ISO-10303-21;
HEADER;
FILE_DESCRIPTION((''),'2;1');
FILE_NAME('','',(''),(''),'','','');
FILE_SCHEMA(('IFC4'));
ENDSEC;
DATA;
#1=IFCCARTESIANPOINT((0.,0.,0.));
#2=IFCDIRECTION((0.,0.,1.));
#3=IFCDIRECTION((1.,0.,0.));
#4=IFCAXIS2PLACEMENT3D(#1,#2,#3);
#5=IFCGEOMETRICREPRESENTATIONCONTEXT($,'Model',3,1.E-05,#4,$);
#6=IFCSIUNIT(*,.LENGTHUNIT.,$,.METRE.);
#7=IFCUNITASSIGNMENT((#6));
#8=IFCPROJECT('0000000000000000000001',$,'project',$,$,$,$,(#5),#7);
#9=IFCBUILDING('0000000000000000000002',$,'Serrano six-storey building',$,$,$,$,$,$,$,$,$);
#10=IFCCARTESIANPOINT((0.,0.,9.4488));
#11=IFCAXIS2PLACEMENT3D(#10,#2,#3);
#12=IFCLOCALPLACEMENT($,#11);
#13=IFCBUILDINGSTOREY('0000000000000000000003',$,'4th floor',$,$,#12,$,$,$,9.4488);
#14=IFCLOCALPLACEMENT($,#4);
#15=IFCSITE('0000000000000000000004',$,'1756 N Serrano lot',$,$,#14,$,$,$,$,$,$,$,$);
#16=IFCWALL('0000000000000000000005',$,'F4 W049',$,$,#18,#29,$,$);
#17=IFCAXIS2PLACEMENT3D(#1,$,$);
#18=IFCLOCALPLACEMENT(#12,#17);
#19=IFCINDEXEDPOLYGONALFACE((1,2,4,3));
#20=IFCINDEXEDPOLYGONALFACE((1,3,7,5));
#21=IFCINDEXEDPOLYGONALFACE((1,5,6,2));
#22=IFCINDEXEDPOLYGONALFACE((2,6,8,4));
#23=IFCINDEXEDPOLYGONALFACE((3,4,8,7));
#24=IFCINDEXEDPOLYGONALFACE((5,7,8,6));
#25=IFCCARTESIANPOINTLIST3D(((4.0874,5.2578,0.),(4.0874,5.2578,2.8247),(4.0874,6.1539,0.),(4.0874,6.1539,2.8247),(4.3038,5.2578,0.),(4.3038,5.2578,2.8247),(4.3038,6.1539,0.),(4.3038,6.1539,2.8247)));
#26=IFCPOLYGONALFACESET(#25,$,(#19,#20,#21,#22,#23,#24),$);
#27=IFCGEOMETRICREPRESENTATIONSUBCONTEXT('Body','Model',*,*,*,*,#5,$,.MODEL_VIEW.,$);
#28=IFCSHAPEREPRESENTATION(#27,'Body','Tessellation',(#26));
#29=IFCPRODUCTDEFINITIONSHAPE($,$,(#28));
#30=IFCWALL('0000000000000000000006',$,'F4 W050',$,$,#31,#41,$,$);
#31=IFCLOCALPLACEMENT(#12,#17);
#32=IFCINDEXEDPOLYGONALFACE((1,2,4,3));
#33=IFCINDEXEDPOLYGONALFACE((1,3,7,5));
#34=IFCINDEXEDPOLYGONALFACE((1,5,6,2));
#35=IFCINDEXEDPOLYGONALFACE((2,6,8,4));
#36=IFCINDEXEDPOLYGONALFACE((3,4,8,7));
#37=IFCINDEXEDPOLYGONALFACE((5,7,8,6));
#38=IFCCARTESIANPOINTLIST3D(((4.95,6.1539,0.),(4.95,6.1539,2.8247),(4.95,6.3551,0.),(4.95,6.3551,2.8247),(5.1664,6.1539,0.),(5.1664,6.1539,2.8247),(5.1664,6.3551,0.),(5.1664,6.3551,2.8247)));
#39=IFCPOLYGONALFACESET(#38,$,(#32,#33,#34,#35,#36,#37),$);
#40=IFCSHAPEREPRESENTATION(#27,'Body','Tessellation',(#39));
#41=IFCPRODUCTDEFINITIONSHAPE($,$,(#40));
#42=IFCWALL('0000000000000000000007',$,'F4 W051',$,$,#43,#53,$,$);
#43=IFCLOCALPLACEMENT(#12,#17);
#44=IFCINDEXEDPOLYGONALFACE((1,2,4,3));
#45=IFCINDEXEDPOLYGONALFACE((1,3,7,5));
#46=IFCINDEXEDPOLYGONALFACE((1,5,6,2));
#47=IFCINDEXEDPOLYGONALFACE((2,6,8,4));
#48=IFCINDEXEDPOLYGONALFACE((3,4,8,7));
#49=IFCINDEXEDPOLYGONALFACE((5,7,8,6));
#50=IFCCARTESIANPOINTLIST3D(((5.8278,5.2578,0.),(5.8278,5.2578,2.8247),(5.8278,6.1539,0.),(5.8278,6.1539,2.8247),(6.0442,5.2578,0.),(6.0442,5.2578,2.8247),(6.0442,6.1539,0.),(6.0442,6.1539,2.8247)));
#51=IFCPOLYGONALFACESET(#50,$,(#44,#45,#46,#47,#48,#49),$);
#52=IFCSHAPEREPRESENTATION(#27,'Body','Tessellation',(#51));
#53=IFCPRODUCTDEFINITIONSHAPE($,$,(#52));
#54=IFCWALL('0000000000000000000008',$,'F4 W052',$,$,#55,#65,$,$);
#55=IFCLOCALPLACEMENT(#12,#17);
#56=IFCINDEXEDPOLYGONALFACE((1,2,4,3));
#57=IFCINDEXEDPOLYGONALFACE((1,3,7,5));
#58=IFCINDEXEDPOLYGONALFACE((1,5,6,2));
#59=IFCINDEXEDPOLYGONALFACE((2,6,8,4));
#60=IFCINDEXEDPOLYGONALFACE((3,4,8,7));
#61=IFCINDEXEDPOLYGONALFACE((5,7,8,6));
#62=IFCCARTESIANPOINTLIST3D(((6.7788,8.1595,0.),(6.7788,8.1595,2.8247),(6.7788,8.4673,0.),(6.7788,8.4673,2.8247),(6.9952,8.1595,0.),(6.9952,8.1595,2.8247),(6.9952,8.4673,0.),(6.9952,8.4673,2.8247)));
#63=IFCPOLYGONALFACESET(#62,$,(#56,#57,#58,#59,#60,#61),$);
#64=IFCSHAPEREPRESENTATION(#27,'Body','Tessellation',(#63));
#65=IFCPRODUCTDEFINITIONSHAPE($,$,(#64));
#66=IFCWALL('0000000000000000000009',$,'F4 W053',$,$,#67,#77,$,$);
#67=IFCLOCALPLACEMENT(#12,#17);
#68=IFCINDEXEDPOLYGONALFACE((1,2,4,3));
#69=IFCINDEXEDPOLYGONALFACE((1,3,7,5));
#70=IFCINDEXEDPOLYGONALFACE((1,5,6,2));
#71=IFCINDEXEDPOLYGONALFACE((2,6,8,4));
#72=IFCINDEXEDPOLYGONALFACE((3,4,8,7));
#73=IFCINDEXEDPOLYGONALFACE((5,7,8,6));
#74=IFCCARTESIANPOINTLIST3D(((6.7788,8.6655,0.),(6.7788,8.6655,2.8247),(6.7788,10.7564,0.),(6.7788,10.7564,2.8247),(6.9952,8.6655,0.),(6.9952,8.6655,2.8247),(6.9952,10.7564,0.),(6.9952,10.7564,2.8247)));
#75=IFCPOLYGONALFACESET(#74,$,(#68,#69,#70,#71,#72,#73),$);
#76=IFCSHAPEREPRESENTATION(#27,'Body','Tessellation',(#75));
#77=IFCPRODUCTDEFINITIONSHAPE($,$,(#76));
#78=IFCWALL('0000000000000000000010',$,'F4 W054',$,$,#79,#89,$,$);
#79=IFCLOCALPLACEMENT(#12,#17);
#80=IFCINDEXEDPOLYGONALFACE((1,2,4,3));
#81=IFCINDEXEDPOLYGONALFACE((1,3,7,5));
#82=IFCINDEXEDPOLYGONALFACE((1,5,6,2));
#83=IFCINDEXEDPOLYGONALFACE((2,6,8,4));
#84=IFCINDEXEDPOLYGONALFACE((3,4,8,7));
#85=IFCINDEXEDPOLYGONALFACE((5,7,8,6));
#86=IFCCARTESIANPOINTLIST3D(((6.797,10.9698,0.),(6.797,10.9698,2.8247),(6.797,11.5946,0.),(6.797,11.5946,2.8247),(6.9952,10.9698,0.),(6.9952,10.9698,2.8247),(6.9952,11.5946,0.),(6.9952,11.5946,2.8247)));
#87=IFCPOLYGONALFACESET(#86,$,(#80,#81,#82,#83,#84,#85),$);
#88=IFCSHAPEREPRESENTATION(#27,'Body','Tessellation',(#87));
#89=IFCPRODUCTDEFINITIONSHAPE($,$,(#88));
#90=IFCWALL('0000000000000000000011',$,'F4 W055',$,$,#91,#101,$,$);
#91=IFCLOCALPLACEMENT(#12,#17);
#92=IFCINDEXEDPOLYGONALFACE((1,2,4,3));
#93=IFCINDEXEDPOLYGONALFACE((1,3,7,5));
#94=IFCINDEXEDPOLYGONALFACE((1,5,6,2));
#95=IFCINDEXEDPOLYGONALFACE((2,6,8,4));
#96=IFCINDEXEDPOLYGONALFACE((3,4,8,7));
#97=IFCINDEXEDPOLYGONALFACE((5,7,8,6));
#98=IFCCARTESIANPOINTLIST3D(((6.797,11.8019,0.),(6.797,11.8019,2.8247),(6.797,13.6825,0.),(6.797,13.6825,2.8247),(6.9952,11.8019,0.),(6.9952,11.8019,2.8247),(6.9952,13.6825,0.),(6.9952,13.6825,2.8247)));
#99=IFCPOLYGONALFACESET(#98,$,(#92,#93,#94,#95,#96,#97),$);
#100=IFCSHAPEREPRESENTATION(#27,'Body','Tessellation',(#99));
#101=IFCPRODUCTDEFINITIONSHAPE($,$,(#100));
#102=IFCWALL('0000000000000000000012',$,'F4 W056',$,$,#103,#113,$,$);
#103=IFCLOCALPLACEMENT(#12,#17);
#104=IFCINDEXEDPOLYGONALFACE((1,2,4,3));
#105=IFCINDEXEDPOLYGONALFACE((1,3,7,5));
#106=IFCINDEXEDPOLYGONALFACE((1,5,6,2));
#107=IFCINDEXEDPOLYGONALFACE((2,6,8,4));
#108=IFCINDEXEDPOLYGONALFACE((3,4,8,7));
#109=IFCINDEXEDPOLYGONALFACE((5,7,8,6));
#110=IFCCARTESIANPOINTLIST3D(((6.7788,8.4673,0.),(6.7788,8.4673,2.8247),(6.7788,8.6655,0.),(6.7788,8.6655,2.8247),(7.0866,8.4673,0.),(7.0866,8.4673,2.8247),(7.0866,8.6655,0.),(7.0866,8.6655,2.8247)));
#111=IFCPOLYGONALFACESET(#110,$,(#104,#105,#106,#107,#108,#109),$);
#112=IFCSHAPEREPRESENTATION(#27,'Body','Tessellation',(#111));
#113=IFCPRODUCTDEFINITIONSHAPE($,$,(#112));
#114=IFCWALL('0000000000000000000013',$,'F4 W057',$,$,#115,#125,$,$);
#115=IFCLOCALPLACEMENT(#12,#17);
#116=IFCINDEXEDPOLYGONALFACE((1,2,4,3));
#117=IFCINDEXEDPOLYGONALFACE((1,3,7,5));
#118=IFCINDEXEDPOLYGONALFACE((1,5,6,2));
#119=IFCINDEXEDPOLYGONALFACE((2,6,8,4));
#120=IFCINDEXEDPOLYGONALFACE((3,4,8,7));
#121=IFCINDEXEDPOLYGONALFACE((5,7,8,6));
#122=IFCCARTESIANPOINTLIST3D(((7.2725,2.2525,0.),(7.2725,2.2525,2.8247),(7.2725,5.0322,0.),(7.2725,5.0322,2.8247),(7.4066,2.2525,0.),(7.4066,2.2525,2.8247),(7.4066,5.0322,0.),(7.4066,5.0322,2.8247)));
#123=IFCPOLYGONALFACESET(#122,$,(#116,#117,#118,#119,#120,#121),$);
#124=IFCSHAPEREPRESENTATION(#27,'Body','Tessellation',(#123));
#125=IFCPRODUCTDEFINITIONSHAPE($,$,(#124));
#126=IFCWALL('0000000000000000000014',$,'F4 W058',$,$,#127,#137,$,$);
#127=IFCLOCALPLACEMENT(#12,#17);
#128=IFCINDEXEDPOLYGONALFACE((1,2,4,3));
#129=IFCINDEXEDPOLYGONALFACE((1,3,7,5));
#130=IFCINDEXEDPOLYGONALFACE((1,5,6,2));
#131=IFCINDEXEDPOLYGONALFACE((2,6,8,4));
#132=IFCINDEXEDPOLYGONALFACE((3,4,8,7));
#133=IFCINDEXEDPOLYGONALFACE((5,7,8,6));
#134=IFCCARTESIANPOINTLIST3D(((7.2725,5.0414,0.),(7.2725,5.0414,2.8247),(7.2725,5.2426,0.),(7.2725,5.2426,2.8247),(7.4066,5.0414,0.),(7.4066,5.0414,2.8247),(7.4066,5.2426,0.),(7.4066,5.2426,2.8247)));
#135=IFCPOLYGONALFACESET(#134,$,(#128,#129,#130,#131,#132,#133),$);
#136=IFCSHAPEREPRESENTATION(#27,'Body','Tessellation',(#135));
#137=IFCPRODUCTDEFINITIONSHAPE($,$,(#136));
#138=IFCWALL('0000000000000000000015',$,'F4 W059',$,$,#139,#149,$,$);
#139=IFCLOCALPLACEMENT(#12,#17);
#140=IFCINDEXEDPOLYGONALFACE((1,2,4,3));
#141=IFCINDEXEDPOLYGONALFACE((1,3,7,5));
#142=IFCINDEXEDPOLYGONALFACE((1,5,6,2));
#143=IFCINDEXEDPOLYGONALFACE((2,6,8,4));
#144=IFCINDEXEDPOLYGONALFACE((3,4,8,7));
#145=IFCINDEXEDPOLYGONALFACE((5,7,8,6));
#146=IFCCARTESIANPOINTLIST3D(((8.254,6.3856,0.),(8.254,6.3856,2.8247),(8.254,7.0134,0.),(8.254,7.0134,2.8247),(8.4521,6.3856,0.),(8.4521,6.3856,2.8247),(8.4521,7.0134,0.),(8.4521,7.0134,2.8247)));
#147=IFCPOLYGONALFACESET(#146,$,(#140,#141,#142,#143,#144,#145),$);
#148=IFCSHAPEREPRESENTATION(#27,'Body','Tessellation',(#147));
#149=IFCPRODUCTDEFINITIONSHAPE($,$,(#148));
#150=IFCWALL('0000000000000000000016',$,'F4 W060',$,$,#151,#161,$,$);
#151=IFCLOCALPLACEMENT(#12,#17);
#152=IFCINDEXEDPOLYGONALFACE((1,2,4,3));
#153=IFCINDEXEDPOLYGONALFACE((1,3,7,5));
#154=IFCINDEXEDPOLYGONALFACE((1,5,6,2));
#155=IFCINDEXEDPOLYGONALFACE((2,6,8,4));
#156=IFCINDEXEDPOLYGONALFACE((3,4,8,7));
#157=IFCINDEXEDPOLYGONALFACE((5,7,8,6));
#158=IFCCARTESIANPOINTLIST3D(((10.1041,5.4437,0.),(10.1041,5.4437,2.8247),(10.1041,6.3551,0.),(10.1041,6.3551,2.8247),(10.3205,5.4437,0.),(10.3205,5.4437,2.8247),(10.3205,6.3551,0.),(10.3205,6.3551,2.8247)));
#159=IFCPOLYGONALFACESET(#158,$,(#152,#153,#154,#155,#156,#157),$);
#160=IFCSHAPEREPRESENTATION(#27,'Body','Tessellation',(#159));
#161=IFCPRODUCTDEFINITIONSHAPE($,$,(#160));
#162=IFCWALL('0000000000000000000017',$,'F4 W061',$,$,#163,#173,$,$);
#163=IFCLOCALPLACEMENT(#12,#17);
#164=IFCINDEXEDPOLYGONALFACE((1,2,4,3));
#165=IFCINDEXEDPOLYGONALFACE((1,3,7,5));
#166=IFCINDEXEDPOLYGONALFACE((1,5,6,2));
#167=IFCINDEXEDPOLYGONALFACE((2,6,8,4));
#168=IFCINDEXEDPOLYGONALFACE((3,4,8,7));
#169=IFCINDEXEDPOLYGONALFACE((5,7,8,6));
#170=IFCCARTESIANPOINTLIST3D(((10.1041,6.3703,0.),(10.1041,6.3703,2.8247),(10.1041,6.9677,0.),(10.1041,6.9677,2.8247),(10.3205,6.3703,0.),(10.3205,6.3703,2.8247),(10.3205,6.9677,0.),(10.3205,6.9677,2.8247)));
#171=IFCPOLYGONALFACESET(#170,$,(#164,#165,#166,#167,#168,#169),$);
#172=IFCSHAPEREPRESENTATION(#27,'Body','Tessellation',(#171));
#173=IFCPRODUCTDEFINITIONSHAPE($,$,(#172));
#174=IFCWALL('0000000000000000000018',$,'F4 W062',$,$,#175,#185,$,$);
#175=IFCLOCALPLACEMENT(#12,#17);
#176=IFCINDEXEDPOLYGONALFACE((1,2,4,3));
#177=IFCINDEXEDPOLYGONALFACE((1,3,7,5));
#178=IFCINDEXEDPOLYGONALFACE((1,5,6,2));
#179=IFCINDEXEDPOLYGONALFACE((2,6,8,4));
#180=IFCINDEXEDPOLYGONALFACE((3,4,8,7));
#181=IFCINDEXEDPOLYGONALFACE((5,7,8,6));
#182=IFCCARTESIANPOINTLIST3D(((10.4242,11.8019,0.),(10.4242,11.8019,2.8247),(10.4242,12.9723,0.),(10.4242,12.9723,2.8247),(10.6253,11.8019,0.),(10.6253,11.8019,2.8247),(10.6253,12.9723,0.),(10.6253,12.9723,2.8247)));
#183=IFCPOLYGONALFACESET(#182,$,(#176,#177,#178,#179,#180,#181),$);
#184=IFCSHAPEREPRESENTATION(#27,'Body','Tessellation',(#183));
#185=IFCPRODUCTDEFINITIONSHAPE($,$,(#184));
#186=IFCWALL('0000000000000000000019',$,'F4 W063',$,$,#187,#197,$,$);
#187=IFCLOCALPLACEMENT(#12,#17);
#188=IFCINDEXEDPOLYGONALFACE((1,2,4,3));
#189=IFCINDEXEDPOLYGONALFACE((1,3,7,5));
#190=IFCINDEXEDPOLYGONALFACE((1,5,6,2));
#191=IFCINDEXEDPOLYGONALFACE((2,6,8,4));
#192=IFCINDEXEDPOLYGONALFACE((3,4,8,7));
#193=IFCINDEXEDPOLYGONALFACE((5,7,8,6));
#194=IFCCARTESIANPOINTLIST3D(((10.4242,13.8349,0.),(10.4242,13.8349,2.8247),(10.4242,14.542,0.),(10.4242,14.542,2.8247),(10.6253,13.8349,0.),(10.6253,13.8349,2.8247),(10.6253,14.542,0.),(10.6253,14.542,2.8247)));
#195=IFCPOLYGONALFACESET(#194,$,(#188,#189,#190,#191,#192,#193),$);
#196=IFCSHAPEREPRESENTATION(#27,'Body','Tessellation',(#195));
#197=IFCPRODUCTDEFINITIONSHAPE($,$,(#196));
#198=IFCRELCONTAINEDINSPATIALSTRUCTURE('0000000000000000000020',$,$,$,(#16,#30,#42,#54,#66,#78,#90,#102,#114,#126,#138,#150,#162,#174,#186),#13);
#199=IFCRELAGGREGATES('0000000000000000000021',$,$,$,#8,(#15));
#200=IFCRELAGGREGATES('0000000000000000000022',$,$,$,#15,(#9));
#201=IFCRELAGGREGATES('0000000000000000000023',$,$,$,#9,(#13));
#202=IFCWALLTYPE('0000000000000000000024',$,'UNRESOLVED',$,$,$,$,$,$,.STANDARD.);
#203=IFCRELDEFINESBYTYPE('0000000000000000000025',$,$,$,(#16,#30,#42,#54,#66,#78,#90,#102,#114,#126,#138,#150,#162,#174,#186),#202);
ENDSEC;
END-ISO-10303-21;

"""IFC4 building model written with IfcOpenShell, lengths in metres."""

from ifc_helpers import new_model, si_unit, frame, origin_with_axes, place, context, subcontext, project, spatial, polyline, outline, extrude, type_object, element, save


model = new_model("IFC4")

# Units and contexts
model_context = context("Model", 3, precision=1e-05, world=origin_with_axes())
body_context = subcontext(model_context, "Body", "Model", "MODEL_VIEW")
ifc_project = project(units=[si_unit("LENGTHUNIT", "METRE")], contexts=[model_context])

# Site, building, storey
site_placement = place(None, origin_with_axes())
site = spatial("IfcSite", under=ifc_project, at=site_placement, Name="1756 N Serrano lot")
building = spatial("IfcBuilding", under=site, Name="Serrano six-storey building")
storey_placement = place(None, frame((0.0, 0.0, 9.4488), z_axis=(0.0, 0.0, 1.0), x_axis=(1.0, 0.0, 0.0)))
storey = spatial("IfcBuildingStorey", under=building, at=storey_placement, Name="4th floor", Elevation=9.4488)

# Walls
wall_type = type_object("IfcWallType", Name="UNRESOLVED", PredefinedType="STANDARD")
wall_1_placement = place(storey_placement, frame((0.0, 0.0, -9.4488), z_axis=(0.0, 0.0, 1.0), x_axis=(1.0, 0.0, 0.0)))
element("IfcWall", 1, at=wall_1_placement, inside=storey, type_object=wall_type, Name="F4 W049", context=body_context, shape_type="SweptSolid", body=[
    extrude(outline(polyline([(4.0874, 6.1539), (4.3038, 6.1539), (4.3038, 5.2578), (4.0874, 5.2578), (4.0874, 6.1539)])), frame((0.0, 0.0, 9.4488)), (0.0, 0.0, 1.0), 2.8247),
])
wall_2_placement = place(storey_placement, frame((0.0, 0.0, -9.4488), z_axis=(0.0, 0.0, 1.0), x_axis=(1.0, 0.0, 0.0)))
element("IfcWall", 2, at=wall_2_placement, inside=storey, type_object=wall_type, Name="F4 W050", context=body_context, shape_type="SweptSolid", body=[
    extrude(outline(polyline([(4.95, 6.3551), (5.1664, 6.3551), (5.1664, 6.1539), (4.95, 6.1539), (4.95, 6.3551)])), frame((0.0, 0.0, 9.4488)), (0.0, 0.0, 1.0), 2.8247),
])
wall_3_placement = place(storey_placement, frame((0.0, 0.0, -9.4488), z_axis=(0.0, 0.0, 1.0), x_axis=(1.0, 0.0, 0.0)))
element("IfcWall", 3, at=wall_3_placement, inside=storey, type_object=wall_type, Name="F4 W051", context=body_context, shape_type="SweptSolid", body=[
    extrude(outline(polyline([(5.8278, 6.1539), (6.0442, 6.1539), (6.0442, 5.2578), (5.8278, 5.2578), (5.8278, 6.1539)])), frame((0.0, 0.0, 9.4488)), (0.0, 0.0, 1.0), 2.8247),
])
wall_4_placement = place(storey_placement, frame((0.0, 0.0, -9.4488), z_axis=(0.0, 0.0, 1.0), x_axis=(1.0, 0.0, 0.0)))
element("IfcWall", 4, at=wall_4_placement, inside=storey, type_object=wall_type, Name="F4 W052", context=body_context, shape_type="SweptSolid", body=[
    extrude(outline(polyline([(6.7788, 8.4673), (6.9952, 8.4673), (6.9952, 8.1595), (6.7788, 8.1595), (6.7788, 8.4673)])), frame((0.0, 0.0, 9.4488)), (0.0, 0.0, 1.0), 2.8247),
])
wall_5_placement = place(storey_placement, frame((0.0, 0.0, -9.4488), z_axis=(0.0, 0.0, 1.0), x_axis=(1.0, 0.0, 0.0)))
element("IfcWall", 5, at=wall_5_placement, inside=storey, type_object=wall_type, Name="F4 W053", context=body_context, shape_type="SweptSolid", body=[
    extrude(outline(polyline([(6.7788, 10.7564), (6.9952, 10.7564), (6.9952, 8.6655), (6.7788, 8.6655), (6.7788, 10.7564)])), frame((0.0, 0.0, 9.4488)), (0.0, 0.0, 1.0), 2.8247),
])
wall_6_placement = place(storey_placement, frame((0.0, 0.0, -9.4488), z_axis=(0.0, 0.0, 1.0), x_axis=(1.0, 0.0, 0.0)))
element("IfcWall", 6, at=wall_6_placement, inside=storey, type_object=wall_type, Name="F4 W054", context=body_context, shape_type="SweptSolid", body=[
    extrude(outline(polyline([(6.797, 11.5946), (6.9952, 11.5946), (6.9952, 10.9698), (6.797, 10.9698), (6.797, 11.5946)])), frame((0.0, 0.0, 9.4488)), (0.0, 0.0, 1.0), 2.8247),
])
wall_7_placement = place(storey_placement, frame((0.0, 0.0, -9.4488), z_axis=(0.0, 0.0, 1.0), x_axis=(1.0, 0.0, 0.0)))
element("IfcWall", 7, at=wall_7_placement, inside=storey, type_object=wall_type, Name="F4 W055", context=body_context, shape_type="SweptSolid", body=[
    extrude(outline(polyline([(6.797, 13.6825), (6.9952, 13.6825), (6.9952, 11.8019), (6.797, 11.8019), (6.797, 13.6825)])), frame((0.0, 0.0, 9.4488)), (0.0, 0.0, 1.0), 2.8247),
])
wall_8_placement = place(storey_placement, frame((0.0, 0.0, -9.4488), z_axis=(0.0, 0.0, 1.0), x_axis=(1.0, 0.0, 0.0)))
element("IfcWall", 8, at=wall_8_placement, inside=storey, type_object=wall_type, Name="F4 W056", context=body_context, shape_type="SweptSolid", body=[
    extrude(outline(polyline([(6.7788, 8.6655), (7.0866, 8.6655), (7.0866, 8.4673), (6.7788, 8.4673), (6.7788, 8.6655)])), frame((0.0, 0.0, 9.4488)), (0.0, 0.0, 1.0), 2.8247),
])
wall_9_placement = place(storey_placement, frame((0.0, 0.0, -9.4488), z_axis=(0.0, 0.0, 1.0), x_axis=(1.0, 0.0, 0.0)))
element("IfcWall", 9, at=wall_9_placement, inside=storey, type_object=wall_type, Name="F4 W057", context=body_context, shape_type="SweptSolid", body=[
    extrude(outline(polyline([(7.2725, 5.0322), (7.4066, 5.0322), (7.4066, 2.2525), (7.2725, 2.2525), (7.2725, 5.0322)])), frame((0.0, 0.0, 9.4488)), (0.0, 0.0, 1.0), 2.8247),
])
wall_10_placement = place(storey_placement, frame((0.0, 0.0, -9.4488), z_axis=(0.0, 0.0, 1.0), x_axis=(1.0, 0.0, 0.0)))
element("IfcWall", 10, at=wall_10_placement, inside=storey, type_object=wall_type, Name="F4 W058", context=body_context, shape_type="SweptSolid", body=[
    extrude(outline(polyline([(7.2725, 5.2426), (7.4066, 5.2426), (7.4066, 5.0414), (7.2725, 5.0414), (7.2725, 5.2426)])), frame((0.0, 0.0, 9.4488)), (0.0, 0.0, 1.0), 2.8247),
])
wall_11_placement = place(storey_placement, frame((0.0, 0.0, -9.4488), z_axis=(0.0, 0.0, 1.0), x_axis=(1.0, 0.0, 0.0)))
element("IfcWall", 11, at=wall_11_placement, inside=storey, type_object=wall_type, Name="F4 W059", context=body_context, shape_type="SweptSolid", body=[
    extrude(outline(polyline([(8.254, 7.0134), (8.4521, 7.0134), (8.4521, 6.3856), (8.254, 6.3856), (8.254, 7.0134)])), frame((0.0, 0.0, 9.4488)), (0.0, 0.0, 1.0), 2.8247),
])
wall_12_placement = place(storey_placement, frame((0.0, 0.0, -9.4488), z_axis=(0.0, 0.0, 1.0), x_axis=(1.0, 0.0, 0.0)))
element("IfcWall", 12, at=wall_12_placement, inside=storey, type_object=wall_type, Name="F4 W060", context=body_context, shape_type="SweptSolid", body=[
    extrude(outline(polyline([(10.1041, 6.3551), (10.3205, 6.3551), (10.3205, 5.4437), (10.1041, 5.4437), (10.1041, 6.3551)])), frame((0.0, 0.0, 9.4488)), (0.0, 0.0, 1.0), 2.8247),
])
wall_13_placement = place(storey_placement, frame((0.0, 0.0, -9.4488), z_axis=(0.0, 0.0, 1.0), x_axis=(1.0, 0.0, 0.0)))
element("IfcWall", 13, at=wall_13_placement, inside=storey, type_object=wall_type, Name="F4 W061", context=body_context, shape_type="SweptSolid", body=[
    extrude(outline(polyline([(10.1041, 6.9677), (10.3205, 6.9677), (10.3205, 6.3703), (10.1041, 6.3703), (10.1041, 6.9677)])), frame((0.0, 0.0, 9.4488)), (0.0, 0.0, 1.0), 2.8247),
])
wall_14_placement = place(storey_placement, frame((0.0, 0.0, -9.4488), z_axis=(0.0, 0.0, 1.0), x_axis=(1.0, 0.0, 0.0)))
element("IfcWall", 14, at=wall_14_placement, inside=storey, type_object=wall_type, Name="F4 W062", context=body_context, shape_type="SweptSolid", body=[
    extrude(outline(polyline([(10.4242, 12.9723), (10.6253, 12.9723), (10.6253, 11.8019), (10.4242, 11.8019), (10.4242, 12.9723)])), frame((0.0, 0.0, 9.4488)), (0.0, 0.0, 1.0), 2.8247),
])
wall_15_placement = place(storey_placement, frame((0.0, 0.0, -9.4488), z_axis=(0.0, 0.0, 1.0), x_axis=(1.0, 0.0, 0.0)))
element("IfcWall", 15, at=wall_15_placement, inside=storey, type_object=wall_type, Name="F4 W063", context=body_context, shape_type="SweptSolid", body=[
    extrude(outline(polyline([(10.4242, 14.542), (10.6253, 14.542), (10.6253, 13.8349), (10.4242, 13.8349), (10.4242, 14.542)])), frame((0.0, 0.0, 9.4488)), (0.0, 0.0, 1.0), 2.8247),
])

save(model, "model.ifc")
